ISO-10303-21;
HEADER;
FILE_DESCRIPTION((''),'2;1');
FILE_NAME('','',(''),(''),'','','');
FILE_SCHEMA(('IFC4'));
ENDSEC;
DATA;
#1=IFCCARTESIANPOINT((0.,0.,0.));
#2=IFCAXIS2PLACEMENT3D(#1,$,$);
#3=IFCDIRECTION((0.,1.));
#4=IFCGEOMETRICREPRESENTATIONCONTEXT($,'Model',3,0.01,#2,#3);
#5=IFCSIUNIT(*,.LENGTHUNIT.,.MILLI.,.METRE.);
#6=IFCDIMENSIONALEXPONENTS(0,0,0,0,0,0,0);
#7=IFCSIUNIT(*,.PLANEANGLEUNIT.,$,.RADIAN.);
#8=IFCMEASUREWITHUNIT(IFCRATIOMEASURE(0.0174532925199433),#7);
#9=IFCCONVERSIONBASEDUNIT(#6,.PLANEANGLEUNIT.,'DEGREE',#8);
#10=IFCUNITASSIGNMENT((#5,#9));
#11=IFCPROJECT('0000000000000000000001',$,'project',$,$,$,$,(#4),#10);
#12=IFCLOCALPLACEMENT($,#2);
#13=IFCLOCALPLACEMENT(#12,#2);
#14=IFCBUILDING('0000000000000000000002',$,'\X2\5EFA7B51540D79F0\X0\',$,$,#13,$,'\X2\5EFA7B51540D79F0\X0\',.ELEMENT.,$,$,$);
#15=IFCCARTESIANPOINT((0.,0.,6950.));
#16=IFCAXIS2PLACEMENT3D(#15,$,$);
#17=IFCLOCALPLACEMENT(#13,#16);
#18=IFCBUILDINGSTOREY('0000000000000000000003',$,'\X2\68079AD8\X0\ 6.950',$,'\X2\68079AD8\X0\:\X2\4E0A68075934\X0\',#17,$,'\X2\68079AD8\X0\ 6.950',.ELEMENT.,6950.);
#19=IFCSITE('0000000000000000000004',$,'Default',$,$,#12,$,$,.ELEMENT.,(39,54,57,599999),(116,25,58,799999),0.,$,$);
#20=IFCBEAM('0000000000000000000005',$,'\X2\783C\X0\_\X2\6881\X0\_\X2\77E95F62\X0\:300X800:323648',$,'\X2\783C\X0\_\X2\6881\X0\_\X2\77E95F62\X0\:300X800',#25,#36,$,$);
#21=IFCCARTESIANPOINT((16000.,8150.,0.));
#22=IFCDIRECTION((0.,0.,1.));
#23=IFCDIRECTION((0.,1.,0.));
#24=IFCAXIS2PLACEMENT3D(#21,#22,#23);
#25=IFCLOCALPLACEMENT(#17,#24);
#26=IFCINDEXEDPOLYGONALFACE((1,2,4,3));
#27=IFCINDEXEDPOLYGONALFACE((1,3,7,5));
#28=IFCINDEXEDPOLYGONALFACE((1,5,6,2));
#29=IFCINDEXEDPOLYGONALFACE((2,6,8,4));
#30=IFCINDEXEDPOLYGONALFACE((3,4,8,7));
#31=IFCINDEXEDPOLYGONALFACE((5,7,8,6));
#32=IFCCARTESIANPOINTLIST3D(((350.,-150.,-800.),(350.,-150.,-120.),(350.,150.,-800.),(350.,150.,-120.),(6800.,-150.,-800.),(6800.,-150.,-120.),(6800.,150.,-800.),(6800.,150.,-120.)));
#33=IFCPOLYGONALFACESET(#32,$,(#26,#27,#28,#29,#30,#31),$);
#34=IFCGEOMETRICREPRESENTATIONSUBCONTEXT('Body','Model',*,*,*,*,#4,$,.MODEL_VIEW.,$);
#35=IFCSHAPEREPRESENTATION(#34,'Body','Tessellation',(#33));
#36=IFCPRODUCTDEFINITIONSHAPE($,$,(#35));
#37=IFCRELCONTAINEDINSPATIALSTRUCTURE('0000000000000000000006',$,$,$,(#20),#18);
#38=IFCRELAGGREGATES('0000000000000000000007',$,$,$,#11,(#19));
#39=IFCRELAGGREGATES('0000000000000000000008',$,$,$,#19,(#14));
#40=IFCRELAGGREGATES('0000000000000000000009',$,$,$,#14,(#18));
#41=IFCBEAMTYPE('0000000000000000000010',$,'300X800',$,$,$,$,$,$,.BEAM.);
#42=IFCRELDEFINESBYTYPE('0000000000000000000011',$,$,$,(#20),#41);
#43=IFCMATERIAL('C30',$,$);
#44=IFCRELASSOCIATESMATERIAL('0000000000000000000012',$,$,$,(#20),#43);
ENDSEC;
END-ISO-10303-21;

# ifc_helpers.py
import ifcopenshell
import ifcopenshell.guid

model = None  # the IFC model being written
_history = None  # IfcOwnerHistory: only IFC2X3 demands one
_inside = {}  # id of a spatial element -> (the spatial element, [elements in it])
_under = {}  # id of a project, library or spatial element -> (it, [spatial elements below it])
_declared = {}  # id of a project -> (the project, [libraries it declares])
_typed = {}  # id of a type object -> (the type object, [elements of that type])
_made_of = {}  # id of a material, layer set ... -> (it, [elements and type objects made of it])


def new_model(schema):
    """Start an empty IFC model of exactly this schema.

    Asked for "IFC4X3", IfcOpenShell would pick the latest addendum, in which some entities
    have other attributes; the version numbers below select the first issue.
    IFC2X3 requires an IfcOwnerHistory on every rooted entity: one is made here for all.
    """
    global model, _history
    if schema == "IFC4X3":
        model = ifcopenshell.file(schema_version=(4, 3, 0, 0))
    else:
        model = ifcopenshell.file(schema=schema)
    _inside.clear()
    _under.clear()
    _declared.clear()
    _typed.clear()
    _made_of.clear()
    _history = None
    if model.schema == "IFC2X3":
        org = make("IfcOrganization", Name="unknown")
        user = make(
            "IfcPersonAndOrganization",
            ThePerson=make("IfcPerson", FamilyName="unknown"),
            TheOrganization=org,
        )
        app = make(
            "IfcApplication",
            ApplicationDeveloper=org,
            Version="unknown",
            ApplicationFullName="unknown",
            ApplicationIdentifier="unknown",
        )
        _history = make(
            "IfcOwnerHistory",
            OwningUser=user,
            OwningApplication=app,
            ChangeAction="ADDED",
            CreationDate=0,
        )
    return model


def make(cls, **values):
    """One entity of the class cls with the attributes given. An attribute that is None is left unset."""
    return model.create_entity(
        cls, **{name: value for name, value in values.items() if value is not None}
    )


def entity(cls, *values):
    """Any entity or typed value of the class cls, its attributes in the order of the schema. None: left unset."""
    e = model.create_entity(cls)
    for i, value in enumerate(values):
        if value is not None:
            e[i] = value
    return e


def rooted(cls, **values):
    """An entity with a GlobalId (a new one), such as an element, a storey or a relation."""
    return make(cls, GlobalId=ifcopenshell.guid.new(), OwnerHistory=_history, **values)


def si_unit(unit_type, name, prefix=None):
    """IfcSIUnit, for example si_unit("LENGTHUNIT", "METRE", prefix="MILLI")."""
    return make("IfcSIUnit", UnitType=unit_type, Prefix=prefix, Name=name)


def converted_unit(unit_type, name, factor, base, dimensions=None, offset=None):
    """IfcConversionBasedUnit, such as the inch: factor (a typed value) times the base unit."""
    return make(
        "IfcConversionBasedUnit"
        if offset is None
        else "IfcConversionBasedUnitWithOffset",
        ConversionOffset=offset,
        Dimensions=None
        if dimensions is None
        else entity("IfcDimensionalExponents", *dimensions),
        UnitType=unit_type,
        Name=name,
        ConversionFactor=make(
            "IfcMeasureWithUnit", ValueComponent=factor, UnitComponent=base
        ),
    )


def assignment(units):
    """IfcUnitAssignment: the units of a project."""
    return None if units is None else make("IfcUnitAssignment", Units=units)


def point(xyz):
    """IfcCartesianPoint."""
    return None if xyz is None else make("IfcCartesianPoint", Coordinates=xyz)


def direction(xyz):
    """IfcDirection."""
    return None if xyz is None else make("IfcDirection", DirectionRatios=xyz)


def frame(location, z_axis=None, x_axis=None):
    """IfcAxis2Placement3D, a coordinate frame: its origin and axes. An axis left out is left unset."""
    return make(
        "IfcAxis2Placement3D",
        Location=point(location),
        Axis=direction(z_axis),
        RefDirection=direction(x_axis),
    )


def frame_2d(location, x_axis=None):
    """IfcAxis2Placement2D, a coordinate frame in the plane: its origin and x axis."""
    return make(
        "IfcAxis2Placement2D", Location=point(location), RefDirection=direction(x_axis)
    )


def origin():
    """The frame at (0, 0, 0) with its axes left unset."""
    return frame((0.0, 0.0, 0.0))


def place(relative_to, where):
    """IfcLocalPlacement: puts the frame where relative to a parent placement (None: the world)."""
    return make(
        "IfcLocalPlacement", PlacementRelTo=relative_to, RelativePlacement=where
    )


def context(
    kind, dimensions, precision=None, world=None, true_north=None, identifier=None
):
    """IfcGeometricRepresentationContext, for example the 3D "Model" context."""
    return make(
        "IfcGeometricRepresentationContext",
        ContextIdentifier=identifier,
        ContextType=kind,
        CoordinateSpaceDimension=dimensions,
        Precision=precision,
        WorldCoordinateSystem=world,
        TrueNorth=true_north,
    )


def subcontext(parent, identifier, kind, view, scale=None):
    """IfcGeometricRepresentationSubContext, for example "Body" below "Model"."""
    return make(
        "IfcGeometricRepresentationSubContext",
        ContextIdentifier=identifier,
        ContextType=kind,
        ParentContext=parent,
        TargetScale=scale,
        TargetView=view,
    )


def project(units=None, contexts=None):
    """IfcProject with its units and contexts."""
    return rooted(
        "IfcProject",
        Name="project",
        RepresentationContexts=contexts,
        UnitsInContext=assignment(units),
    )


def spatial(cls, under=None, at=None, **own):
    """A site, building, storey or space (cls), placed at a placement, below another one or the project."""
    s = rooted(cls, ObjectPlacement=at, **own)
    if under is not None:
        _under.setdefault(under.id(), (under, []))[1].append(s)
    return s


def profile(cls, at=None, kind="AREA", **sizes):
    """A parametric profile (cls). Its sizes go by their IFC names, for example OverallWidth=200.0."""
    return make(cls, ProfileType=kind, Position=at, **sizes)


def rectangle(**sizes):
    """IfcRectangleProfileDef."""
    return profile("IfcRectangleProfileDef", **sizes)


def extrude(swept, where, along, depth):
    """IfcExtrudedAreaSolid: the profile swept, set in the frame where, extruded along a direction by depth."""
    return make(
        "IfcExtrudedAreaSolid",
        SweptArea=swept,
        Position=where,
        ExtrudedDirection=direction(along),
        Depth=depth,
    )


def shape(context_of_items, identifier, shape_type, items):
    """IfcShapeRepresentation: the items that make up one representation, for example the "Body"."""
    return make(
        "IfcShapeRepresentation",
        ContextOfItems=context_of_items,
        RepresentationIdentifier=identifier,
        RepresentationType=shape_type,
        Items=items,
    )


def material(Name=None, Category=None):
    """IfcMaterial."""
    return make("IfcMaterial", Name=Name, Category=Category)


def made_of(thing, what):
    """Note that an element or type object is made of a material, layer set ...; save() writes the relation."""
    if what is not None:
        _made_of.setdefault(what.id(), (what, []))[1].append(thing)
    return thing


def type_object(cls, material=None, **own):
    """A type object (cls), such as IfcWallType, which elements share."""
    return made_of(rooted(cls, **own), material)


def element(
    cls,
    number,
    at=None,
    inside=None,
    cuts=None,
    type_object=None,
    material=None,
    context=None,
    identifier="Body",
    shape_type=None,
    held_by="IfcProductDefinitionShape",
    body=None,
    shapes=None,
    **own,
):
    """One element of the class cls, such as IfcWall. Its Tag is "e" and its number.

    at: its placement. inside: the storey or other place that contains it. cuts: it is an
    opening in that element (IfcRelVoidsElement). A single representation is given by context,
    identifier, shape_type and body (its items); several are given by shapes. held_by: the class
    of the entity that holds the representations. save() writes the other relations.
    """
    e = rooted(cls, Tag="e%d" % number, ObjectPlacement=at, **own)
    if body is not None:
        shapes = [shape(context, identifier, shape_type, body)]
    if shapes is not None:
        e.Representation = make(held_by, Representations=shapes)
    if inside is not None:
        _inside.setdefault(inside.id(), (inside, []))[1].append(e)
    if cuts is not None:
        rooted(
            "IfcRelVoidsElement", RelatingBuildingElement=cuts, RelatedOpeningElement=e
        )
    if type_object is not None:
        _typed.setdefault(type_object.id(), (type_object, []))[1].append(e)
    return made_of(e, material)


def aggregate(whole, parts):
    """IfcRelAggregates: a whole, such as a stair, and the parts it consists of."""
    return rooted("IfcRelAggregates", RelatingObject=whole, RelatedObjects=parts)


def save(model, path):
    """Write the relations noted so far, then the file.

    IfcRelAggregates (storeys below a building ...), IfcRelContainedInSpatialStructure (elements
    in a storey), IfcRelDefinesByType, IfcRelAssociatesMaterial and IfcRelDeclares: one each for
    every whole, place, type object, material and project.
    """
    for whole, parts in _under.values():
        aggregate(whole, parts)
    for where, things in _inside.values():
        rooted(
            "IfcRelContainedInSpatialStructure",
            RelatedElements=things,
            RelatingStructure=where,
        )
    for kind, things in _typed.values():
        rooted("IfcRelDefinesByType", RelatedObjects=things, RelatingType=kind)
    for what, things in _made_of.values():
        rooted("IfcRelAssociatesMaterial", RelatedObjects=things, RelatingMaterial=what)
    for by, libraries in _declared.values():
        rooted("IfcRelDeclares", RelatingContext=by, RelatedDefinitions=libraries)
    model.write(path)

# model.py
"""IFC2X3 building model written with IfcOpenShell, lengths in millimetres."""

from ifc_helpers import new_model, entity, si_unit, converted_unit, direction, frame, frame_2d, origin, place, context, subcontext, project, spatial, rectangle, extrude, material, type_object, element, save


model = new_model("IFC2X3")

# Units and contexts
model_context = context("Model", 3, precision=0.01, world=origin(), true_north=direction((0.0, 1.0)))
body_context = subcontext(model_context, "Body", "Model", "MODEL_VIEW")
ifc_project = project(units=[si_unit("LENGTHUNIT", "METRE", prefix="MILLI"), converted_unit("PLANEANGLEUNIT", "DEGREE", entity("IfcRatioMeasure", 0.0174532925199433), si_unit("PLANEANGLEUNIT", "RADIAN"), dimensions=[0, 0, 0, 0, 0, 0, 0])], contexts=[model_context])

# Site, building, storey
site_placement = place(None, origin())
site = spatial("IfcSite", under=ifc_project, at=site_placement, Name="Default", CompositionType="ELEMENT", RefLatitude=(39, 54, 57, 599999), RefLongitude=(116, 25, 58, 799999), RefElevation=0.0)
building_placement = place(site_placement, origin())
building = spatial("IfcBuilding", under=site, at=building_placement, Name="建筑名称", LongName="建筑名称", CompositionType="ELEMENT")
storey_placement = place(building_placement, frame((0.0, 0.0, 6950.0)))
storey = spatial("IfcBuildingStorey", under=building, at=storey_placement, Name="标高 6.950", ObjectType="标高:上标头", LongName="标高 6.950", CompositionType="ELEMENT", Elevation=6950.0)

# Beam
ifc_material_1 = material(Name="C30")
beam_type_1 = type_object("IfcBeamType", Name="300X800", PredefinedType="BEAM")
beam_1_placement = place(storey_placement, frame((16000.0, 8150.0, 0.0), z_axis=(0.0, 0.0, 1.0), x_axis=(0.0, 1.0, 0.0)))
element("IfcBeam", 1, at=beam_1_placement, inside=storey, type_object=beam_type_1, material=ifc_material_1, Name="砼_梁_矩形:300X800:323648", ObjectType="砼_梁_矩形:300X800", context=body_context, shape_type="SweptSolid", body=[
    extrude(rectangle(XDim=680.0, YDim=300.0, at=frame_2d((0.0, 0.0), x_axis=(1.0, 0.0))), frame((350.0, 0.0, -460.0), z_axis=(1.0, 0.0, 0.0), x_axis=(0.0, 0.0, -1.0)), (0.0, 0.0, 1.0), 6450.0),
])

save(model, "model.ifc")
